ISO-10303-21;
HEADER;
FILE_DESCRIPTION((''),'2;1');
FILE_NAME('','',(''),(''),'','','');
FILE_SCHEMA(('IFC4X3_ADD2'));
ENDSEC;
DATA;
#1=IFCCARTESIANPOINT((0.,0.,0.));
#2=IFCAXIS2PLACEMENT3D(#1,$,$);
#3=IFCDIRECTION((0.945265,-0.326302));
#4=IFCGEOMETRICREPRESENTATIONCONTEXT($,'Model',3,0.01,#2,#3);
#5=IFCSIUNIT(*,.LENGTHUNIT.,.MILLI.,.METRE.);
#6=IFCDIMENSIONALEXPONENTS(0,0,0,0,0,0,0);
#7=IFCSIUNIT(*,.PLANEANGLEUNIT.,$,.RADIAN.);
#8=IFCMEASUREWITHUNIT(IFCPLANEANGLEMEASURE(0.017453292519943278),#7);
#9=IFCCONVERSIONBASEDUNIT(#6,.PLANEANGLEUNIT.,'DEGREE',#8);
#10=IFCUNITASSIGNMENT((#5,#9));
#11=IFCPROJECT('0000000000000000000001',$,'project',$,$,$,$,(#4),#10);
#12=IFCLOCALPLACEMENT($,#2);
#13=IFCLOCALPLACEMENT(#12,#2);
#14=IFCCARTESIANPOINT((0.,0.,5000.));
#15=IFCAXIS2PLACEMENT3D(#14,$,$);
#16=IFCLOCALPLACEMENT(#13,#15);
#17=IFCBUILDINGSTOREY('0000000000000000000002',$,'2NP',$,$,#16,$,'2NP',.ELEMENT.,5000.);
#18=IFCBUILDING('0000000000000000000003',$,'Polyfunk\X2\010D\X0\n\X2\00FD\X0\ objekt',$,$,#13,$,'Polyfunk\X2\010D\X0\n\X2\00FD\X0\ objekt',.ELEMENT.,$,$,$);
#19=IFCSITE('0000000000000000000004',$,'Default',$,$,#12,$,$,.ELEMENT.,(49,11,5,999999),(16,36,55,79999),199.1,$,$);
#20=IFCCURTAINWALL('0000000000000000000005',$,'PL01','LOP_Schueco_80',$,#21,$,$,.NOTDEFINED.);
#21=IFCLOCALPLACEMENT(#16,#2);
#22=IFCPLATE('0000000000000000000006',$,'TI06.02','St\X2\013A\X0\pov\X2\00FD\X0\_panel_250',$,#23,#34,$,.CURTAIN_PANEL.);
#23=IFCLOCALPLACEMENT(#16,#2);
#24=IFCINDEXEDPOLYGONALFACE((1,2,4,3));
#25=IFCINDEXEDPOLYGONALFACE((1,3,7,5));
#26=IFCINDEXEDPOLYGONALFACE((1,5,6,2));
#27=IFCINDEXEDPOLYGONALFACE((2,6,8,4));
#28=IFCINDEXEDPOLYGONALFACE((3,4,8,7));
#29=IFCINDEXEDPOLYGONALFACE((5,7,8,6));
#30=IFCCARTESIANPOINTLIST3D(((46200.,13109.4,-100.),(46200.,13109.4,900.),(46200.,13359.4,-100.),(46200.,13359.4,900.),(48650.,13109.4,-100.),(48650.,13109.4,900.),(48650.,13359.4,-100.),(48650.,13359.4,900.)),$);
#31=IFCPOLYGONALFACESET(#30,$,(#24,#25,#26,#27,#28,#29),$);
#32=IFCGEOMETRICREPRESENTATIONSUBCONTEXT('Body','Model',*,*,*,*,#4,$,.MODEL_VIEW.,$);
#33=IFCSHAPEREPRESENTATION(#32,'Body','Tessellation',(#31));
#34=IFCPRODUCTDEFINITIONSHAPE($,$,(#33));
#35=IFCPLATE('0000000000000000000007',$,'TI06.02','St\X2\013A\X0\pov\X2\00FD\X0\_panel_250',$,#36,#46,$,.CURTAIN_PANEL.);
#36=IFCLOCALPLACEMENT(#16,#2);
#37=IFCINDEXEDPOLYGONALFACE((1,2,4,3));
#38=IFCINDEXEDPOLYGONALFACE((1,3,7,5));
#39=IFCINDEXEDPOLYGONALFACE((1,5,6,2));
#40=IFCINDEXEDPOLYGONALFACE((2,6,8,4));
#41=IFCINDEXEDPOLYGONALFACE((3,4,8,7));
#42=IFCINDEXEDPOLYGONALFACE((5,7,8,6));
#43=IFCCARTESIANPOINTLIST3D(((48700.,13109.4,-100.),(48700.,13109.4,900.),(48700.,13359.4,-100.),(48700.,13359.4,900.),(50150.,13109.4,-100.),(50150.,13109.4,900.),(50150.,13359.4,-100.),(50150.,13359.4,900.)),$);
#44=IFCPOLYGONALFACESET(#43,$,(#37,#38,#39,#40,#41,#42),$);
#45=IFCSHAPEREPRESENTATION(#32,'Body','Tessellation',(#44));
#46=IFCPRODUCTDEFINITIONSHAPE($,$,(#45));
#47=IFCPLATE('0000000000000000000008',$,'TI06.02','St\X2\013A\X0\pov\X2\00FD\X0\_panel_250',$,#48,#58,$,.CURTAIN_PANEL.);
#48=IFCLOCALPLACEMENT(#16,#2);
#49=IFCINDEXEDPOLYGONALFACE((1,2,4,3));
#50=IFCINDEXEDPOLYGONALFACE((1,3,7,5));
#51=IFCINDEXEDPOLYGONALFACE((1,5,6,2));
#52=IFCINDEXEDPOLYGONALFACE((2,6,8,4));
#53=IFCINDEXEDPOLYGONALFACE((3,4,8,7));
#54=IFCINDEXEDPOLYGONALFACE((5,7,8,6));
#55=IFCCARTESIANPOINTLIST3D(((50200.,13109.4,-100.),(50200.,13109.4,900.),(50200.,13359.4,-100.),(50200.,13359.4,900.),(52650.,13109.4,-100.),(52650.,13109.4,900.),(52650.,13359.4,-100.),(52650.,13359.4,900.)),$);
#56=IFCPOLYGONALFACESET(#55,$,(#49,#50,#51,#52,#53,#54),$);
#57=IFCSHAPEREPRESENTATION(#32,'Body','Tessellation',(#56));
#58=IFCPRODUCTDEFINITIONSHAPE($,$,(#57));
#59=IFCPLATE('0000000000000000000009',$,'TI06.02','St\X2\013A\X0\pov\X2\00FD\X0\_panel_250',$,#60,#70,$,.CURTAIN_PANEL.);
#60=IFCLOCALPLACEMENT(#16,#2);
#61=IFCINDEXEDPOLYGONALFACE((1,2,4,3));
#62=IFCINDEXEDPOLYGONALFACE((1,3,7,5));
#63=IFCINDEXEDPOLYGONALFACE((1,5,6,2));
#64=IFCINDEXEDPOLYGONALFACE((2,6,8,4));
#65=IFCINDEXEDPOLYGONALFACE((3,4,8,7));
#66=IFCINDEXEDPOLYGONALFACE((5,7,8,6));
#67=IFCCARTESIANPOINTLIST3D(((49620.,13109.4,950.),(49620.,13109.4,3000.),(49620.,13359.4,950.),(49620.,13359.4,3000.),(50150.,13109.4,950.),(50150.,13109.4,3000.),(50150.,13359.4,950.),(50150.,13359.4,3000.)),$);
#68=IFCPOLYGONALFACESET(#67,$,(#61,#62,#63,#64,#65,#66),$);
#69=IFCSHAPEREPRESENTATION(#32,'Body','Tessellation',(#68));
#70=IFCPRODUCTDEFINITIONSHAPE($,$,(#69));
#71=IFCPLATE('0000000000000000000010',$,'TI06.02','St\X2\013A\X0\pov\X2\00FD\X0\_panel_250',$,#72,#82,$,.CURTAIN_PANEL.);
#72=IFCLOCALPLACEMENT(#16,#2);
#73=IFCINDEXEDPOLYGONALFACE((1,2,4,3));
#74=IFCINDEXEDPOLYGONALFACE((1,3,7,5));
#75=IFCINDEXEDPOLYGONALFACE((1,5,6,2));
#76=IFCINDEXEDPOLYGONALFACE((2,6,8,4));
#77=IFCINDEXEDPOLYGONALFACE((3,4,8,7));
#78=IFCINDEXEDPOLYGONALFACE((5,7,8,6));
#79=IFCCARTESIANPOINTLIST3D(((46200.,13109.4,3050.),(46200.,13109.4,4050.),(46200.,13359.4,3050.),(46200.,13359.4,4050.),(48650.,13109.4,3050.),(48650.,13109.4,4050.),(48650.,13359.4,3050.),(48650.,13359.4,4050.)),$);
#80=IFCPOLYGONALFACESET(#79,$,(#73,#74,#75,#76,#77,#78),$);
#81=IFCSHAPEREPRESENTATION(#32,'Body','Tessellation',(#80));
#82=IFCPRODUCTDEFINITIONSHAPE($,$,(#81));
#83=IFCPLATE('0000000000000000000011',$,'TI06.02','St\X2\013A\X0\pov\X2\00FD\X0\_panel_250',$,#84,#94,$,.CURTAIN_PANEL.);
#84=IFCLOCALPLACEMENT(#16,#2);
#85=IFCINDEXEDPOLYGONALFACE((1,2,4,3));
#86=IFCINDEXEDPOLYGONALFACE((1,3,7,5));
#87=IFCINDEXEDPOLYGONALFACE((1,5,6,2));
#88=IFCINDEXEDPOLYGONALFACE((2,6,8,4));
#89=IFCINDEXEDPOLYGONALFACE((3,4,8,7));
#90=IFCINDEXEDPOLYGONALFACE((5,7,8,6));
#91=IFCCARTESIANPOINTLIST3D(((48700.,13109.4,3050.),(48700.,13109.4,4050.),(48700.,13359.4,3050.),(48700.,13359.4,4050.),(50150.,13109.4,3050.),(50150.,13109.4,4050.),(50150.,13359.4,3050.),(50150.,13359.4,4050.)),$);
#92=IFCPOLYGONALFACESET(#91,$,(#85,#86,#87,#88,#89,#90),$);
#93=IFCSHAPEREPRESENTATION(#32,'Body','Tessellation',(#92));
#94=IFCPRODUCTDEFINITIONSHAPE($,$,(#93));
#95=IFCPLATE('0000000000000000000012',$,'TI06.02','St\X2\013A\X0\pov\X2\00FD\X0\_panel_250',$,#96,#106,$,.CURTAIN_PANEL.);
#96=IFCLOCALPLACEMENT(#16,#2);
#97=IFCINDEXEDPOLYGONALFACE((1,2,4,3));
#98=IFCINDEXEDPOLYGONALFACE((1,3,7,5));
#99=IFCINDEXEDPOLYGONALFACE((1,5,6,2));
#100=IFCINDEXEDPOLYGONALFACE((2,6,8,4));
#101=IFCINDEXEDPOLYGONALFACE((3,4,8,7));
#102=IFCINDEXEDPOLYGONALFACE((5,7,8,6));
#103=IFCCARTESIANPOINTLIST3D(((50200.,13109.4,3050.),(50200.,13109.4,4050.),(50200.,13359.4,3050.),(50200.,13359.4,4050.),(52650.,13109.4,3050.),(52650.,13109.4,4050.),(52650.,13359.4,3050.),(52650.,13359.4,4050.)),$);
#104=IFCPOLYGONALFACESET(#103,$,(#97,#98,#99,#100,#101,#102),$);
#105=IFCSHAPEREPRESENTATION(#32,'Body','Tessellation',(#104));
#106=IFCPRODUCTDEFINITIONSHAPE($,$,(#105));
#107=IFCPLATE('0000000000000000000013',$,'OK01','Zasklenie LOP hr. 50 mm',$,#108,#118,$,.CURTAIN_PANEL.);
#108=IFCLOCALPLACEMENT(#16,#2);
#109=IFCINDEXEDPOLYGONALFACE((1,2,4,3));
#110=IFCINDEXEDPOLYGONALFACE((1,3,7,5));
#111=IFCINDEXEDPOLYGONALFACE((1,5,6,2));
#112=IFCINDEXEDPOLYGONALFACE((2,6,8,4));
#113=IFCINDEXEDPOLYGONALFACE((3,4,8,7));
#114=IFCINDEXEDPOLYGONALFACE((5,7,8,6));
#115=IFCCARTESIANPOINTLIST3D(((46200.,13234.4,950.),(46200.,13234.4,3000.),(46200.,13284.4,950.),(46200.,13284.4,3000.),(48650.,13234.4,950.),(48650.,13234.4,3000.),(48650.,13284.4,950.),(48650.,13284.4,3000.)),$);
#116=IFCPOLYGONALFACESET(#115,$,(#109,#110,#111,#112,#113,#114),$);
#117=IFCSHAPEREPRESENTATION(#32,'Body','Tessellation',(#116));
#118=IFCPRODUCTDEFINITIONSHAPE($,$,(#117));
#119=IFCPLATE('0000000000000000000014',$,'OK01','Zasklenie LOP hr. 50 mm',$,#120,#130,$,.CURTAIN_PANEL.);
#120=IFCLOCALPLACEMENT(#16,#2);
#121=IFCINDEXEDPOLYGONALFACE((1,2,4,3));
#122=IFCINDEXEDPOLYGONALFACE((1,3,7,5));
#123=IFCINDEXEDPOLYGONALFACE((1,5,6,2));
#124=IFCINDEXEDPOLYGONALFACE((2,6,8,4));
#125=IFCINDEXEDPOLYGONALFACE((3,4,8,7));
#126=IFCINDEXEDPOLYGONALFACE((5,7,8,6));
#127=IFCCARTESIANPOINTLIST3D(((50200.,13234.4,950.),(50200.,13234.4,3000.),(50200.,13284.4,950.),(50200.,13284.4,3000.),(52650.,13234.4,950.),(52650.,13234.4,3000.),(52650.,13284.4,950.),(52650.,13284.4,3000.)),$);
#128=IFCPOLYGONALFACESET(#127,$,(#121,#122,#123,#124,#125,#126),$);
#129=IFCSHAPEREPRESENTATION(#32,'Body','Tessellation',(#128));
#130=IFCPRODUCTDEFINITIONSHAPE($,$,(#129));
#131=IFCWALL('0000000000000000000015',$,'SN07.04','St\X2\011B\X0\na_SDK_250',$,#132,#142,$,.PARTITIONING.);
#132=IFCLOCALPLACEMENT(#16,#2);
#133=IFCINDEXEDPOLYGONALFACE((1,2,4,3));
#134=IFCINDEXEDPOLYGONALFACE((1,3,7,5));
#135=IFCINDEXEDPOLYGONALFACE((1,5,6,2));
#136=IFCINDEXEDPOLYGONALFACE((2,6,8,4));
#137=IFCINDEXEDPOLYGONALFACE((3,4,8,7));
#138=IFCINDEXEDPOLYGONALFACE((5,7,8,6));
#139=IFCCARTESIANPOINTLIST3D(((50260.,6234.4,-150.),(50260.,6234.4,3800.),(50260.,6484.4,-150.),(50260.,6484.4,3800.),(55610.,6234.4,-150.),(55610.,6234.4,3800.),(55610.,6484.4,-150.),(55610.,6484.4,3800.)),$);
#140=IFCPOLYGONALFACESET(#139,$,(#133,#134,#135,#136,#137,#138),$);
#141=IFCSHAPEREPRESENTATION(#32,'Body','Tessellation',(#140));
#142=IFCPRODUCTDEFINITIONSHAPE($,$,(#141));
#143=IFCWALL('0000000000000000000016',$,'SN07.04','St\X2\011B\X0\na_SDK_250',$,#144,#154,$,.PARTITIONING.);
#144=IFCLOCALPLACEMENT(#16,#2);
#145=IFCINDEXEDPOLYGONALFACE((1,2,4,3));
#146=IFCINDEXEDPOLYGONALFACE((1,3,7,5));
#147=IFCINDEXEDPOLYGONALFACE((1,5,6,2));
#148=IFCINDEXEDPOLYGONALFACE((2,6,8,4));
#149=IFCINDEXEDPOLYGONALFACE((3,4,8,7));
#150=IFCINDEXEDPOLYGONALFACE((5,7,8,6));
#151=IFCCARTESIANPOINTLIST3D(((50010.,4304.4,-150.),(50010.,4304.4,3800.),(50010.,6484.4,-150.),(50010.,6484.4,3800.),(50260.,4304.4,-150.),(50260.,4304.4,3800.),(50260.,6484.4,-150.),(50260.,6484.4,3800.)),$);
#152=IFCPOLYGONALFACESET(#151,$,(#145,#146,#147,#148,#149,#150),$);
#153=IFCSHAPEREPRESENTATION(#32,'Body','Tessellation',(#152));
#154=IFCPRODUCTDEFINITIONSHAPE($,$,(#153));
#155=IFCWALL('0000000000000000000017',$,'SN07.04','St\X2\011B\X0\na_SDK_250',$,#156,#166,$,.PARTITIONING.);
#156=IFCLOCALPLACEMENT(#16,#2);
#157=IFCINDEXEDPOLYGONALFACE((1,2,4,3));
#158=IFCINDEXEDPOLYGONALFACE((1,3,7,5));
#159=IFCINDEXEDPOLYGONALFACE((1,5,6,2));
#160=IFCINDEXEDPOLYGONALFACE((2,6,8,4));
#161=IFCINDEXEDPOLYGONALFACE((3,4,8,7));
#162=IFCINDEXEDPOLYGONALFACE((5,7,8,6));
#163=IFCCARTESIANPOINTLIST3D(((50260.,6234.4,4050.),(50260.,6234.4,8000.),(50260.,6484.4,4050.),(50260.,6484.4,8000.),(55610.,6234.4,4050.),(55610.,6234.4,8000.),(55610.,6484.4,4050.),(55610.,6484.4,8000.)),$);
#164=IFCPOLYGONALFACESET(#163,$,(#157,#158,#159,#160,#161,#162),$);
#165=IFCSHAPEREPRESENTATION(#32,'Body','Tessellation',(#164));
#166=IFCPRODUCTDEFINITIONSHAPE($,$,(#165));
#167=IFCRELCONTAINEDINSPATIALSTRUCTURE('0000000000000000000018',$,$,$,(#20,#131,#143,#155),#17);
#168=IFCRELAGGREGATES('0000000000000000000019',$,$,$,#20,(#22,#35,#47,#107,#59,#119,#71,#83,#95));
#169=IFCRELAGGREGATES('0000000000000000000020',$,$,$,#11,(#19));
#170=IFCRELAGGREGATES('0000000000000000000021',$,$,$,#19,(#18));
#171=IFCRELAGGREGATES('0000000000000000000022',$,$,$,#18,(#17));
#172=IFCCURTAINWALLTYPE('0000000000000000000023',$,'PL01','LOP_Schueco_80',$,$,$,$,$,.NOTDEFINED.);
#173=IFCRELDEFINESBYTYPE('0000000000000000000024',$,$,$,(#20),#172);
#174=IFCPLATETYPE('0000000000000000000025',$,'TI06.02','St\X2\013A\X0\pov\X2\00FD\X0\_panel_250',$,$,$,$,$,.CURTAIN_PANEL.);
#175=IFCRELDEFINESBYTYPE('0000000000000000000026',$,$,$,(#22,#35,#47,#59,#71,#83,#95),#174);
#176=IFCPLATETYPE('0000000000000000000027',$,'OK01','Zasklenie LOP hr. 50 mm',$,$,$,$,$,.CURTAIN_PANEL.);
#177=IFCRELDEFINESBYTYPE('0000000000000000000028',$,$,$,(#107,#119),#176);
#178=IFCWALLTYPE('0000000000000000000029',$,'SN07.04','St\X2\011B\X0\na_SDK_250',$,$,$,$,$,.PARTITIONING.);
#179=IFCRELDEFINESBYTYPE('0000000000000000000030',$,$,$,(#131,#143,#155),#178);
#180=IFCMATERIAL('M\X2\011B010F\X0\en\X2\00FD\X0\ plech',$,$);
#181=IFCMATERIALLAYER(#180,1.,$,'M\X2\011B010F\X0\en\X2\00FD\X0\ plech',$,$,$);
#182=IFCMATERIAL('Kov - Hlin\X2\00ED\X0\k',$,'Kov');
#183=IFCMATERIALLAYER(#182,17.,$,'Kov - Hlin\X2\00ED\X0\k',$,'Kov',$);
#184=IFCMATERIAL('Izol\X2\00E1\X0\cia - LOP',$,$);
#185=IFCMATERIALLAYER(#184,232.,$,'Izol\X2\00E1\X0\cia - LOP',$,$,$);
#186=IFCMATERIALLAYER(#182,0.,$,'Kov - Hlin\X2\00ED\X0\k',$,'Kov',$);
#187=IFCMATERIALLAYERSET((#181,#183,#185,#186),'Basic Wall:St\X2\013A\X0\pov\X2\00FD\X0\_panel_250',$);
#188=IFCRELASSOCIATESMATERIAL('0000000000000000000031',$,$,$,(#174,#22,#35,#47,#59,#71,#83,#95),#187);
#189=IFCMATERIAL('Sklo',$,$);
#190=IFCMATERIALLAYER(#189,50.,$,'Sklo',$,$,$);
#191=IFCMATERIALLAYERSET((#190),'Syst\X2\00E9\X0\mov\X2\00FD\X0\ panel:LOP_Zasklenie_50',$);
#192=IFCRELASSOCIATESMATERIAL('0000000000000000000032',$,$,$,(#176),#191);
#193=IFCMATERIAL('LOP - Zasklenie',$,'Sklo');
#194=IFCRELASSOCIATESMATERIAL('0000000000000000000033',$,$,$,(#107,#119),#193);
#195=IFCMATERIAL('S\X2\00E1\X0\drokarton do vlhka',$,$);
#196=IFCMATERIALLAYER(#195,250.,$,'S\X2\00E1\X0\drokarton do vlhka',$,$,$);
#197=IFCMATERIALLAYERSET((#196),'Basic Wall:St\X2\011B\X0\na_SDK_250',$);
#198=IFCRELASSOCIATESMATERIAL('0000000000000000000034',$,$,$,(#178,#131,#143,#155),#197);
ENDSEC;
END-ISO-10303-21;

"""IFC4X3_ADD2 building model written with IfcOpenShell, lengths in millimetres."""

from ifc_helpers import new_model, entity, si_unit, converted_unit, direction, frame, frame_2d, origin, origin_2d_with_axis, place, context, subcontext, project, spatial, polyline, rectangle, extrude, clip, bounded_halfspace, source, transform, mapped, material, layer, layer_set, layer_usage, type_object, type_shapes, element, aggregate, save


model = new_model("IFC4X3_ADD2")

# Units and contexts
model_context = context("Model", 3, precision=0.01, world=origin(), true_north=direction((0.945265, -0.326302)))
body_context = subcontext(model_context, "Body", "Model", "MODEL_VIEW")
ifc_project = project(units=[si_unit("LENGTHUNIT", "METRE", prefix="MILLI"), converted_unit("PLANEANGLEUNIT", "DEGREE", entity("IfcPlaneAngleMeasure", 0.017453292519943278), si_unit("PLANEANGLEUNIT", "RADIAN"), dimensions=[0, 0, 0, 0, 0, 0, 0])], contexts=[model_context])

# Site, building, storey
site_placement = place(None, origin())
site = spatial("IfcSite", under=ifc_project, at=site_placement, Name="Default", CompositionType="ELEMENT", RefLatitude=(49, 11, 5, 999999), RefLongitude=(16, 36, 55, 79999), RefElevation=199.1)
building_placement = place(site_placement, origin())
building = spatial("IfcBuilding", under=site, at=building_placement, Name="Polyfunkčný objekt", LongName="Polyfunkčný objekt", CompositionType="ELEMENT")
storey_placement = place(building_placement, frame((0.0, 0.0, 5000.0)))
storey = spatial("IfcBuildingStorey", under=building, at=storey_placement, Name="2NP", LongName="2NP", CompositionType="ELEMENT", Elevation=5000.0)

# Curtain wall, plates
curtain_wall_type = type_object("IfcCurtainWallType", Name="PL01", Description="LOP_Schueco_80", PredefinedType="NOTDEFINED")
curtain_wall_placement = place(storey_placement, frame((0.0, 0.0, -5000.0)))
curtain_wall = element("IfcCurtainWall", 1, at=curtain_wall_placement, inside=storey, type_object=curtain_wall_type, Name="PL01", Description="LOP_Schueco_80", PredefinedType="NOTDEFINED")
ifc_material_1 = material(Name="Měďený plech")
ifc_layer_1 = layer(ifc_material_1, 1.0, Name="Měďený plech")
ifc_material_2 = material(Name="Kov - Hliník", Category="Kov")
ifc_layer_2 = layer(ifc_material_2, 17.0, Name="Kov - Hliník", Category="Kov")
ifc_material_3 = material(Name="Izolácia - LOP")
ifc_layer_3 = layer(ifc_material_3, 232.0, Name="Izolácia - LOP")
ifc_layer_4 = layer(ifc_material_2, 0.0, Name="Kov - Hliník", Category="Kov")
ifc_layer_set_1 = layer_set([ifc_layer_1, ifc_layer_2, ifc_layer_3, ifc_layer_4], Name="Basic Wall:Stĺpový_panel_250")
ifc_layer_usage_1 = layer_usage(ifc_layer_set_1, "AXIS2", "NEGATIVE", 125.0)
plate_type_1 = type_object("IfcPlateType", Name="TI06.02", Description="Stĺpový_panel_250", PredefinedType="CURTAIN_PANEL", material=ifc_layer_set_1)
plate_1_placement = place(storey_placement, frame((46200.0, 13234.4, -100.0)))
plate_1 = element("IfcPlate", 2, at=plate_1_placement, type_object=plate_type_1, material=ifc_layer_usage_1, Name="TI06.02", Description="Stĺpový_panel_250", PredefinedType="CURTAIN_PANEL", context=body_context, shape_type="SweptSolid", body=[
    extrude(rectangle(XDim=250.0, YDim=2450.0, at=frame_2d((0.0, 0.0), x_axis=(1.0, 0.0))), frame((1225.0, 0.0, 0.0), z_axis=(0.0, 0.0, 1.0), x_axis=(0.0, 1.0, 0.0)), (0.0, 0.0, 1.0), 1000.0),
])
ifc_layer_usage_2 = layer_usage(ifc_layer_set_1, "AXIS2", "NEGATIVE", 125.0)
plate_2_placement = place(storey_placement, frame((48700.0, 13234.4, -100.0)))
plate_2 = element("IfcPlate", 3, at=plate_2_placement, type_object=plate_type_1, material=ifc_layer_usage_2, Name="TI06.02", Description="Stĺpový_panel_250", PredefinedType="CURTAIN_PANEL", context=body_context, shape_type="SweptSolid", body=[
    extrude(rectangle(XDim=250.0, YDim=1450.0, at=frame_2d((0.0, 0.0), x_axis=(1.0, 0.0))), frame((725.0, 0.0, 0.0), z_axis=(0.0, 0.0, 1.0), x_axis=(0.0, 1.0, 0.0)), (0.0, 0.0, 1.0), 1000.0),
])
ifc_layer_usage_3 = layer_usage(ifc_layer_set_1, "AXIS2", "NEGATIVE", 125.0)
plate_3_placement = place(storey_placement, frame((50200.0, 13234.4, -100.0)))
plate_3 = element("IfcPlate", 4, at=plate_3_placement, type_object=plate_type_1, material=ifc_layer_usage_3, Name="TI06.02", Description="Stĺpový_panel_250", PredefinedType="CURTAIN_PANEL", context=body_context, shape_type="SweptSolid", body=[
    extrude(rectangle(XDim=250.0, YDim=2450.0, at=origin_2d_with_axis()), frame((1225.0, 0.0, 0.0), z_axis=(0.0, 0.0, 1.0), x_axis=(0.0, 1.0, 0.0)), (0.0, 0.0, 1.0), 1000.0),
])
ifc_layer_usage_4 = layer_usage(ifc_layer_set_1, "AXIS2", "NEGATIVE", 125.0)
plate_4_placement = place(storey_placement, frame((49620.0, 13234.4, 950.0)))
plate_4 = element("IfcPlate", 5, at=plate_4_placement, type_object=plate_type_1, material=ifc_layer_usage_4, Name="TI06.02", Description="Stĺpový_panel_250", PredefinedType="CURTAIN_PANEL", context=body_context, shape_type="SweptSolid", body=[
    extrude(rectangle(XDim=250.0, YDim=530.0, at=frame_2d((0.0, 0.0), x_axis=(1.0, 0.0))), frame((265.0, 0.0, 0.0), z_axis=(0.0, 0.0, 1.0), x_axis=(0.0, 1.0, 0.0)), (0.0, 0.0, 1.0), 2050.0),
])
ifc_layer_usage_5 = layer_usage(ifc_layer_set_1, "AXIS2", "NEGATIVE", 125.0)
plate_5_placement = place(storey_placement, frame((46200.0, 13234.4, 3050.0)))
plate_5 = element("IfcPlate", 6, at=plate_5_placement, type_object=plate_type_1, material=ifc_layer_usage_5, Name="TI06.02", Description="Stĺpový_panel_250", PredefinedType="CURTAIN_PANEL", context=body_context, shape_type="SweptSolid", body=[
    extrude(rectangle(XDim=250.0, YDim=2450.0, at=frame_2d((0.0, 0.0), x_axis=(1.0, 0.0))), frame((1225.0, 0.0, 0.0), z_axis=(0.0, 0.0, 1.0), x_axis=(0.0, 1.0, 0.0)), (0.0, 0.0, 1.0), 1000.0),
])
ifc_layer_usage_6 = layer_usage(ifc_layer_set_1, "AXIS2", "NEGATIVE", 125.0)
plate_6_placement = place(storey_placement, frame((48700.0, 13234.4, 3050.0)))
plate_6 = element("IfcPlate", 7, at=plate_6_placement, type_object=plate_type_1, material=ifc_layer_usage_6, Name="TI06.02", Description="Stĺpový_panel_250", PredefinedType="CURTAIN_PANEL", context=body_context, shape_type="SweptSolid", body=[
    extrude(rectangle(XDim=250.0, YDim=1450.0, at=frame_2d((0.0, 0.0), x_axis=(1.0, 0.0))), frame((725.0, 0.0, 0.0), z_axis=(0.0, 0.0, 1.0), x_axis=(0.0, 1.0, 0.0)), (0.0, 0.0, 1.0), 1000.0),
])
ifc_layer_usage_7 = layer_usage(ifc_layer_set_1, "AXIS2", "NEGATIVE", 125.0)
plate_7_placement = place(storey_placement, frame((50200.0, 13234.4, 3050.0)))
plate_7 = element("IfcPlate", 8, at=plate_7_placement, type_object=plate_type_1, material=ifc_layer_usage_7, Name="TI06.02", Description="Stĺpový_panel_250", PredefinedType="CURTAIN_PANEL", context=body_context, shape_type="SweptSolid", body=[
    extrude(rectangle(XDim=250.0, YDim=2450.0, at=origin_2d_with_axis()), frame((1225.0, 0.0, 0.0), z_axis=(0.0, 0.0, 1.0), x_axis=(0.0, 1.0, 0.0)), (0.0, 0.0, 1.0), 1000.0),
])
ifc_material_4 = material(Name="LOP - Zasklenie", Category="Sklo")
ifc_material_5 = material(Name="Sklo")
ifc_layer_5 = layer(ifc_material_5, 50.0, Name="Sklo")
ifc_layer_set_2 = layer_set([ifc_layer_5], Name="Systémový panel:LOP_Zasklenie_50")
plate_type_2 = type_object("IfcPlateType", Name="OK01", Description="Zasklenie LOP hr. 50 mm", PredefinedType="CURTAIN_PANEL", material=ifc_layer_set_2)
shared_shape_1 = source(origin(), body_context, "Body", "SweptSolid", [
    extrude(rectangle(XDim=50.0, YDim=2450.0, at=origin_2d_with_axis()), frame((0.0, 25.0, 0.0), z_axis=(0.0, 0.0, 1.0), x_axis=(0.0, 1.0, 0.0)), (0.0, 0.0, 1.0), 2050.0),
])
type_shapes(plate_type_2, [shared_shape_1])
plate_8_placement = place(curtain_wall_placement, frame((47425.0, 13234.4, 5950.0)))
plate_8 = element("IfcPlate", 9, at=plate_8_placement, type_object=plate_type_2, material=ifc_material_4, Name="OK01", Description="Zasklenie LOP hr. 50 mm", PredefinedType="CURTAIN_PANEL", context=body_context, shape_type="MappedRepresentation", body=[
    mapped(shared_shape_1, transform((0.0, 0.0, 0.0), scale=1.0)),
])
plate_9_placement = place(curtain_wall_placement, frame((51425.0, 13234.4, 5950.0)))
plate_9 = element("IfcPlate", 10, at=plate_9_placement, type_object=plate_type_2, material=ifc_material_4, Name="OK01", Description="Zasklenie LOP hr. 50 mm", PredefinedType="CURTAIN_PANEL", context=body_context, shape_type="MappedRepresentation", body=[
    mapped(shared_shape_1, transform((0.0, 0.0, 0.0), scale=1.0)),
])

# Walls
ifc_material_6 = material(Name="Sádrokarton do vlhka")
ifc_layer_6 = layer(ifc_material_6, 250.0, Name="Sádrokarton do vlhka")
ifc_layer_set_3 = layer_set([ifc_layer_6], Name="Basic Wall:Stěna_SDK_250")
wall_type_1 = type_object("IfcWallType", Name="SN07.04", Description="Stěna_SDK_250", PredefinedType="PARTITIONING", material=ifc_layer_set_3)
wall_1_placement = place(storey_placement, frame((50260.0, 6359.4, -150.0)))
element("IfcWall", 11, at=wall_1_placement, inside=storey, type_object=wall_type_1, material=ifc_layer_set_3, Name="SN07.04", Description="Stěna_SDK_250", PredefinedType="PARTITIONING", context=body_context, shape_type="Clipping", body=[
    clip(clip(extrude(rectangle(XDim=5350.0, YDim=250.0, at=frame_2d((2675.0, 0.0), x_axis=(-1.0, 0.0))), origin(), (0.0, 0.0, 1.0), 3950.0), bounded_halfspace(frame((5350.0, -125.0, 0.0), z_axis=(0.0, 0.0, 1.0), x_axis=(-1.0, 0.0, 0.0)), True, frame((5350.0, -125.0, 0.0)), polyline([(0.0, 0.0), (0.0, 250.0), (-5350.0, 250.0), (-5350.0, 0.0), (-1670.0, 0.0), (-1520.0, 0.0), (0.0, 0.0)]))), bounded_halfspace(frame((0.0, -125.0, 3950.0), z_axis=(0.0, 0.0, -1.0), x_axis=(1.0, 0.0, 0.0)), True, frame((0.0, -125.0, 3950.0)), polyline([(0.0, 0.0), (3680.0, 0.0), (3830.0, 0.0), (5350.0, 0.0), (5350.0, 250.0), (0.0, 250.0), (0.0, 0.0)]))),
])
wall_2_placement = place(storey_placement, frame((50135.0, 6484.4, -150.0), z_axis=(0.0, 0.0, 1.0), x_axis=(0.0, -1.0, 0.0)))
element("IfcWall", 12, at=wall_2_placement, inside=storey, type_object=wall_type_1, material=ifc_layer_set_3, Name="SN07.04", Description="Stěna_SDK_250", PredefinedType="PARTITIONING", context=body_context, shape_type="Clipping", body=[
    clip(clip(extrude(rectangle(XDim=2180.0, YDim=250.0, at=frame_2d((1090.0, 0.0), x_axis=(-1.0, 0.0))), origin(), (0.0, 0.0, 1.0), 3950.0), bounded_halfspace(frame((2180.0, -125.0, 0.0), z_axis=(0.0, 0.0, 1.0), x_axis=(0.0, -1.0, 0.0)), True, frame((2180.0, -125.0, 0.0)), polyline([(0.0, 0.0), (0.0, 250.0), (-1930.0, 250.0), (-2180.0, 250.0), (-2180.0, 0.0), (0.0, 0.0)]))), bounded_halfspace(frame((0.0, -125.0, 3950.0), z_axis=(0.0, 0.0, -1.0), x_axis=(0.0, 1.0, 0.0)), True, frame((0.0, -125.0, 3950.0)), polyline([(0.0, 0.0), (2180.0, 0.0), (2180.0, 250.0), (250.0, 250.0), (0.0, 250.0), (0.0, 0.0)]))),
])
wall_3_placement = place(storey_placement, frame((50260.0, 6359.4, 4050.0)))
element("IfcWall", 13, at=wall_3_placement, inside=storey, type_object=wall_type_1, material=ifc_layer_set_3, Name="SN07.04", Description="Stěna_SDK_250", PredefinedType="PARTITIONING", context=body_context, shape_type="Clipping", body=[
    clip(clip(extrude(rectangle(XDim=5350.0, YDim=250.0, at=frame_2d((2675.0, 0.0), x_axis=(-1.0, 0.0))), origin(), (0.0, 0.0, 1.0), 3950.0), bounded_halfspace(frame((5350.0, -125.0, 0.0), z_axis=(0.0, 0.0, 1.0), x_axis=(-1.0, 0.0, 0.0)), True, frame((5350.0, -125.0, 0.0)), polyline([(0.0, 0.0), (0.0, 250.0), (-5350.0, 250.0), (-5350.0, 0.0), (-1670.0, 0.0), (-1520.0, 0.0), (0.0, 0.0)]))), bounded_halfspace(frame((0.0, -125.0, 3950.0), z_axis=(0.0, 0.0, -1.0), x_axis=(1.0, 0.0, 0.0)), True, frame((0.0, -125.0, 3950.0)), polyline([(0.0, 0.0), (3680.0, 0.0), (3830.0, 0.0), (5350.0, 0.0), (5350.0, 250.0), (0.0, 250.0), (0.0, 0.0)]))),
])

aggregate(curtain_wall, [plate_1, plate_2, plate_3, plate_8, plate_4, plate_9, plate_5, plate_6, plate_7])

save(model, "model.ifc")
